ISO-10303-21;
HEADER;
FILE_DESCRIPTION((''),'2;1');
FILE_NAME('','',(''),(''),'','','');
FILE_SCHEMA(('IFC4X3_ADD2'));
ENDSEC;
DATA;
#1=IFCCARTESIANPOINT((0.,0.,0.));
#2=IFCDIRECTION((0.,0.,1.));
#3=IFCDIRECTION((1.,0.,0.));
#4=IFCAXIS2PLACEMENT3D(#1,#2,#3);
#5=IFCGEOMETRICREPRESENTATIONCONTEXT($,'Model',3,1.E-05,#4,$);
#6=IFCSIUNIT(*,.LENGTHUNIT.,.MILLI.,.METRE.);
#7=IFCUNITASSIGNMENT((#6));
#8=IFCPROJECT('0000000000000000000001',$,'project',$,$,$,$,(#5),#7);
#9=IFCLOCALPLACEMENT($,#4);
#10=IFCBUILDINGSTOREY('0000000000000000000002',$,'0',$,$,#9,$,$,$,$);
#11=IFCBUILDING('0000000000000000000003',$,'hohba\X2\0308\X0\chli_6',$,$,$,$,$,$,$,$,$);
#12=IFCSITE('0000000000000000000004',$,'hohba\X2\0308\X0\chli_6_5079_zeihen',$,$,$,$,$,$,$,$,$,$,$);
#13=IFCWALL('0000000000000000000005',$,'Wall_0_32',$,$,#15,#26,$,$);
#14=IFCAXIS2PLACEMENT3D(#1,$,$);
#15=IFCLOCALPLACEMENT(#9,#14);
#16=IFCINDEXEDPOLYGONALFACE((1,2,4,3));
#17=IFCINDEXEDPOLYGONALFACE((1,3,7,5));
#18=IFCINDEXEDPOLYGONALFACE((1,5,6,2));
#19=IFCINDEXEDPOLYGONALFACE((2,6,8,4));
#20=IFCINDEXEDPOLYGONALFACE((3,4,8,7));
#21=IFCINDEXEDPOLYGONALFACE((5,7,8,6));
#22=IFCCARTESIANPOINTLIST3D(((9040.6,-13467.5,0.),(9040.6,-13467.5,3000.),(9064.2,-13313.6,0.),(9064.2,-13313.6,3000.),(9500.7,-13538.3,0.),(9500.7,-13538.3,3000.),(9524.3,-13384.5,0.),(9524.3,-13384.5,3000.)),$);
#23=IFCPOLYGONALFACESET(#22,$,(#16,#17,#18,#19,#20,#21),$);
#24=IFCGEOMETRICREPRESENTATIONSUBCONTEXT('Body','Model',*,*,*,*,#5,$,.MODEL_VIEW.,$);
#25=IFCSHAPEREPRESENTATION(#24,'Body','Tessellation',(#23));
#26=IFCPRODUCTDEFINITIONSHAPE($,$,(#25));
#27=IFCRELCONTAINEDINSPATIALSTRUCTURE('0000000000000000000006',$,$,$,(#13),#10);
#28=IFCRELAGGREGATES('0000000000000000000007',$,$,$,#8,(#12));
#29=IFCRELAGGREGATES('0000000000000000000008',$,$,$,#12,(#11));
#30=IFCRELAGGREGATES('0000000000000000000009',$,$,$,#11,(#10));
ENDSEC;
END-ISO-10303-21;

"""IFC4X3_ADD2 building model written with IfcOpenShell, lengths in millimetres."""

from ifc_helpers import new_model, si_unit, frame, origin_with_axes, place, context, subcontext, project, spatial, indexed_curve, outline, extrude, element, save


model = new_model("IFC4X3_ADD2")

# Units and contexts
model_context = context("Model", 3, precision=1e-05, world=origin_with_axes())
body_context = subcontext(model_context, "Body", "Model", "MODEL_VIEW")
ifc_project = project(units=[si_unit("LENGTHUNIT", "METRE", prefix="MILLI")], contexts=[model_context])

# Site, building, storey
site = spatial("IfcSite", under=ifc_project, Name="hohbächli_6_5079_zeihen")
building = spatial("IfcBuilding", under=site, Name="hohbächli_6")
storey_placement = place(None, origin_with_axes())
storey = spatial("IfcBuildingStorey", under=building, at=storey_placement, Name="0")

# Wall
wall_1_placement = place(storey_placement, frame((9040.6, -13467.5, 0.0), z_axis=(0.0, 0.0, 1.0), x_axis=(0.988352, -0.152184, 0.0)))
element("IfcWall", 1, at=wall_1_placement, inside=storey, Name="Wall_0_32", context=body_context, shape_type="SweptSolid", body=[
    extrude(outline(indexed_curve([(0.0, 0.0), (0.0, 155.6), (465.5, 155.6), (465.5, 0.0), (0.0, 0.0)], self_intersect=False)), origin_with_axes(), (0.0, 0.0, 1.0), 3000.0),
])

save(model, "model.ifc")
